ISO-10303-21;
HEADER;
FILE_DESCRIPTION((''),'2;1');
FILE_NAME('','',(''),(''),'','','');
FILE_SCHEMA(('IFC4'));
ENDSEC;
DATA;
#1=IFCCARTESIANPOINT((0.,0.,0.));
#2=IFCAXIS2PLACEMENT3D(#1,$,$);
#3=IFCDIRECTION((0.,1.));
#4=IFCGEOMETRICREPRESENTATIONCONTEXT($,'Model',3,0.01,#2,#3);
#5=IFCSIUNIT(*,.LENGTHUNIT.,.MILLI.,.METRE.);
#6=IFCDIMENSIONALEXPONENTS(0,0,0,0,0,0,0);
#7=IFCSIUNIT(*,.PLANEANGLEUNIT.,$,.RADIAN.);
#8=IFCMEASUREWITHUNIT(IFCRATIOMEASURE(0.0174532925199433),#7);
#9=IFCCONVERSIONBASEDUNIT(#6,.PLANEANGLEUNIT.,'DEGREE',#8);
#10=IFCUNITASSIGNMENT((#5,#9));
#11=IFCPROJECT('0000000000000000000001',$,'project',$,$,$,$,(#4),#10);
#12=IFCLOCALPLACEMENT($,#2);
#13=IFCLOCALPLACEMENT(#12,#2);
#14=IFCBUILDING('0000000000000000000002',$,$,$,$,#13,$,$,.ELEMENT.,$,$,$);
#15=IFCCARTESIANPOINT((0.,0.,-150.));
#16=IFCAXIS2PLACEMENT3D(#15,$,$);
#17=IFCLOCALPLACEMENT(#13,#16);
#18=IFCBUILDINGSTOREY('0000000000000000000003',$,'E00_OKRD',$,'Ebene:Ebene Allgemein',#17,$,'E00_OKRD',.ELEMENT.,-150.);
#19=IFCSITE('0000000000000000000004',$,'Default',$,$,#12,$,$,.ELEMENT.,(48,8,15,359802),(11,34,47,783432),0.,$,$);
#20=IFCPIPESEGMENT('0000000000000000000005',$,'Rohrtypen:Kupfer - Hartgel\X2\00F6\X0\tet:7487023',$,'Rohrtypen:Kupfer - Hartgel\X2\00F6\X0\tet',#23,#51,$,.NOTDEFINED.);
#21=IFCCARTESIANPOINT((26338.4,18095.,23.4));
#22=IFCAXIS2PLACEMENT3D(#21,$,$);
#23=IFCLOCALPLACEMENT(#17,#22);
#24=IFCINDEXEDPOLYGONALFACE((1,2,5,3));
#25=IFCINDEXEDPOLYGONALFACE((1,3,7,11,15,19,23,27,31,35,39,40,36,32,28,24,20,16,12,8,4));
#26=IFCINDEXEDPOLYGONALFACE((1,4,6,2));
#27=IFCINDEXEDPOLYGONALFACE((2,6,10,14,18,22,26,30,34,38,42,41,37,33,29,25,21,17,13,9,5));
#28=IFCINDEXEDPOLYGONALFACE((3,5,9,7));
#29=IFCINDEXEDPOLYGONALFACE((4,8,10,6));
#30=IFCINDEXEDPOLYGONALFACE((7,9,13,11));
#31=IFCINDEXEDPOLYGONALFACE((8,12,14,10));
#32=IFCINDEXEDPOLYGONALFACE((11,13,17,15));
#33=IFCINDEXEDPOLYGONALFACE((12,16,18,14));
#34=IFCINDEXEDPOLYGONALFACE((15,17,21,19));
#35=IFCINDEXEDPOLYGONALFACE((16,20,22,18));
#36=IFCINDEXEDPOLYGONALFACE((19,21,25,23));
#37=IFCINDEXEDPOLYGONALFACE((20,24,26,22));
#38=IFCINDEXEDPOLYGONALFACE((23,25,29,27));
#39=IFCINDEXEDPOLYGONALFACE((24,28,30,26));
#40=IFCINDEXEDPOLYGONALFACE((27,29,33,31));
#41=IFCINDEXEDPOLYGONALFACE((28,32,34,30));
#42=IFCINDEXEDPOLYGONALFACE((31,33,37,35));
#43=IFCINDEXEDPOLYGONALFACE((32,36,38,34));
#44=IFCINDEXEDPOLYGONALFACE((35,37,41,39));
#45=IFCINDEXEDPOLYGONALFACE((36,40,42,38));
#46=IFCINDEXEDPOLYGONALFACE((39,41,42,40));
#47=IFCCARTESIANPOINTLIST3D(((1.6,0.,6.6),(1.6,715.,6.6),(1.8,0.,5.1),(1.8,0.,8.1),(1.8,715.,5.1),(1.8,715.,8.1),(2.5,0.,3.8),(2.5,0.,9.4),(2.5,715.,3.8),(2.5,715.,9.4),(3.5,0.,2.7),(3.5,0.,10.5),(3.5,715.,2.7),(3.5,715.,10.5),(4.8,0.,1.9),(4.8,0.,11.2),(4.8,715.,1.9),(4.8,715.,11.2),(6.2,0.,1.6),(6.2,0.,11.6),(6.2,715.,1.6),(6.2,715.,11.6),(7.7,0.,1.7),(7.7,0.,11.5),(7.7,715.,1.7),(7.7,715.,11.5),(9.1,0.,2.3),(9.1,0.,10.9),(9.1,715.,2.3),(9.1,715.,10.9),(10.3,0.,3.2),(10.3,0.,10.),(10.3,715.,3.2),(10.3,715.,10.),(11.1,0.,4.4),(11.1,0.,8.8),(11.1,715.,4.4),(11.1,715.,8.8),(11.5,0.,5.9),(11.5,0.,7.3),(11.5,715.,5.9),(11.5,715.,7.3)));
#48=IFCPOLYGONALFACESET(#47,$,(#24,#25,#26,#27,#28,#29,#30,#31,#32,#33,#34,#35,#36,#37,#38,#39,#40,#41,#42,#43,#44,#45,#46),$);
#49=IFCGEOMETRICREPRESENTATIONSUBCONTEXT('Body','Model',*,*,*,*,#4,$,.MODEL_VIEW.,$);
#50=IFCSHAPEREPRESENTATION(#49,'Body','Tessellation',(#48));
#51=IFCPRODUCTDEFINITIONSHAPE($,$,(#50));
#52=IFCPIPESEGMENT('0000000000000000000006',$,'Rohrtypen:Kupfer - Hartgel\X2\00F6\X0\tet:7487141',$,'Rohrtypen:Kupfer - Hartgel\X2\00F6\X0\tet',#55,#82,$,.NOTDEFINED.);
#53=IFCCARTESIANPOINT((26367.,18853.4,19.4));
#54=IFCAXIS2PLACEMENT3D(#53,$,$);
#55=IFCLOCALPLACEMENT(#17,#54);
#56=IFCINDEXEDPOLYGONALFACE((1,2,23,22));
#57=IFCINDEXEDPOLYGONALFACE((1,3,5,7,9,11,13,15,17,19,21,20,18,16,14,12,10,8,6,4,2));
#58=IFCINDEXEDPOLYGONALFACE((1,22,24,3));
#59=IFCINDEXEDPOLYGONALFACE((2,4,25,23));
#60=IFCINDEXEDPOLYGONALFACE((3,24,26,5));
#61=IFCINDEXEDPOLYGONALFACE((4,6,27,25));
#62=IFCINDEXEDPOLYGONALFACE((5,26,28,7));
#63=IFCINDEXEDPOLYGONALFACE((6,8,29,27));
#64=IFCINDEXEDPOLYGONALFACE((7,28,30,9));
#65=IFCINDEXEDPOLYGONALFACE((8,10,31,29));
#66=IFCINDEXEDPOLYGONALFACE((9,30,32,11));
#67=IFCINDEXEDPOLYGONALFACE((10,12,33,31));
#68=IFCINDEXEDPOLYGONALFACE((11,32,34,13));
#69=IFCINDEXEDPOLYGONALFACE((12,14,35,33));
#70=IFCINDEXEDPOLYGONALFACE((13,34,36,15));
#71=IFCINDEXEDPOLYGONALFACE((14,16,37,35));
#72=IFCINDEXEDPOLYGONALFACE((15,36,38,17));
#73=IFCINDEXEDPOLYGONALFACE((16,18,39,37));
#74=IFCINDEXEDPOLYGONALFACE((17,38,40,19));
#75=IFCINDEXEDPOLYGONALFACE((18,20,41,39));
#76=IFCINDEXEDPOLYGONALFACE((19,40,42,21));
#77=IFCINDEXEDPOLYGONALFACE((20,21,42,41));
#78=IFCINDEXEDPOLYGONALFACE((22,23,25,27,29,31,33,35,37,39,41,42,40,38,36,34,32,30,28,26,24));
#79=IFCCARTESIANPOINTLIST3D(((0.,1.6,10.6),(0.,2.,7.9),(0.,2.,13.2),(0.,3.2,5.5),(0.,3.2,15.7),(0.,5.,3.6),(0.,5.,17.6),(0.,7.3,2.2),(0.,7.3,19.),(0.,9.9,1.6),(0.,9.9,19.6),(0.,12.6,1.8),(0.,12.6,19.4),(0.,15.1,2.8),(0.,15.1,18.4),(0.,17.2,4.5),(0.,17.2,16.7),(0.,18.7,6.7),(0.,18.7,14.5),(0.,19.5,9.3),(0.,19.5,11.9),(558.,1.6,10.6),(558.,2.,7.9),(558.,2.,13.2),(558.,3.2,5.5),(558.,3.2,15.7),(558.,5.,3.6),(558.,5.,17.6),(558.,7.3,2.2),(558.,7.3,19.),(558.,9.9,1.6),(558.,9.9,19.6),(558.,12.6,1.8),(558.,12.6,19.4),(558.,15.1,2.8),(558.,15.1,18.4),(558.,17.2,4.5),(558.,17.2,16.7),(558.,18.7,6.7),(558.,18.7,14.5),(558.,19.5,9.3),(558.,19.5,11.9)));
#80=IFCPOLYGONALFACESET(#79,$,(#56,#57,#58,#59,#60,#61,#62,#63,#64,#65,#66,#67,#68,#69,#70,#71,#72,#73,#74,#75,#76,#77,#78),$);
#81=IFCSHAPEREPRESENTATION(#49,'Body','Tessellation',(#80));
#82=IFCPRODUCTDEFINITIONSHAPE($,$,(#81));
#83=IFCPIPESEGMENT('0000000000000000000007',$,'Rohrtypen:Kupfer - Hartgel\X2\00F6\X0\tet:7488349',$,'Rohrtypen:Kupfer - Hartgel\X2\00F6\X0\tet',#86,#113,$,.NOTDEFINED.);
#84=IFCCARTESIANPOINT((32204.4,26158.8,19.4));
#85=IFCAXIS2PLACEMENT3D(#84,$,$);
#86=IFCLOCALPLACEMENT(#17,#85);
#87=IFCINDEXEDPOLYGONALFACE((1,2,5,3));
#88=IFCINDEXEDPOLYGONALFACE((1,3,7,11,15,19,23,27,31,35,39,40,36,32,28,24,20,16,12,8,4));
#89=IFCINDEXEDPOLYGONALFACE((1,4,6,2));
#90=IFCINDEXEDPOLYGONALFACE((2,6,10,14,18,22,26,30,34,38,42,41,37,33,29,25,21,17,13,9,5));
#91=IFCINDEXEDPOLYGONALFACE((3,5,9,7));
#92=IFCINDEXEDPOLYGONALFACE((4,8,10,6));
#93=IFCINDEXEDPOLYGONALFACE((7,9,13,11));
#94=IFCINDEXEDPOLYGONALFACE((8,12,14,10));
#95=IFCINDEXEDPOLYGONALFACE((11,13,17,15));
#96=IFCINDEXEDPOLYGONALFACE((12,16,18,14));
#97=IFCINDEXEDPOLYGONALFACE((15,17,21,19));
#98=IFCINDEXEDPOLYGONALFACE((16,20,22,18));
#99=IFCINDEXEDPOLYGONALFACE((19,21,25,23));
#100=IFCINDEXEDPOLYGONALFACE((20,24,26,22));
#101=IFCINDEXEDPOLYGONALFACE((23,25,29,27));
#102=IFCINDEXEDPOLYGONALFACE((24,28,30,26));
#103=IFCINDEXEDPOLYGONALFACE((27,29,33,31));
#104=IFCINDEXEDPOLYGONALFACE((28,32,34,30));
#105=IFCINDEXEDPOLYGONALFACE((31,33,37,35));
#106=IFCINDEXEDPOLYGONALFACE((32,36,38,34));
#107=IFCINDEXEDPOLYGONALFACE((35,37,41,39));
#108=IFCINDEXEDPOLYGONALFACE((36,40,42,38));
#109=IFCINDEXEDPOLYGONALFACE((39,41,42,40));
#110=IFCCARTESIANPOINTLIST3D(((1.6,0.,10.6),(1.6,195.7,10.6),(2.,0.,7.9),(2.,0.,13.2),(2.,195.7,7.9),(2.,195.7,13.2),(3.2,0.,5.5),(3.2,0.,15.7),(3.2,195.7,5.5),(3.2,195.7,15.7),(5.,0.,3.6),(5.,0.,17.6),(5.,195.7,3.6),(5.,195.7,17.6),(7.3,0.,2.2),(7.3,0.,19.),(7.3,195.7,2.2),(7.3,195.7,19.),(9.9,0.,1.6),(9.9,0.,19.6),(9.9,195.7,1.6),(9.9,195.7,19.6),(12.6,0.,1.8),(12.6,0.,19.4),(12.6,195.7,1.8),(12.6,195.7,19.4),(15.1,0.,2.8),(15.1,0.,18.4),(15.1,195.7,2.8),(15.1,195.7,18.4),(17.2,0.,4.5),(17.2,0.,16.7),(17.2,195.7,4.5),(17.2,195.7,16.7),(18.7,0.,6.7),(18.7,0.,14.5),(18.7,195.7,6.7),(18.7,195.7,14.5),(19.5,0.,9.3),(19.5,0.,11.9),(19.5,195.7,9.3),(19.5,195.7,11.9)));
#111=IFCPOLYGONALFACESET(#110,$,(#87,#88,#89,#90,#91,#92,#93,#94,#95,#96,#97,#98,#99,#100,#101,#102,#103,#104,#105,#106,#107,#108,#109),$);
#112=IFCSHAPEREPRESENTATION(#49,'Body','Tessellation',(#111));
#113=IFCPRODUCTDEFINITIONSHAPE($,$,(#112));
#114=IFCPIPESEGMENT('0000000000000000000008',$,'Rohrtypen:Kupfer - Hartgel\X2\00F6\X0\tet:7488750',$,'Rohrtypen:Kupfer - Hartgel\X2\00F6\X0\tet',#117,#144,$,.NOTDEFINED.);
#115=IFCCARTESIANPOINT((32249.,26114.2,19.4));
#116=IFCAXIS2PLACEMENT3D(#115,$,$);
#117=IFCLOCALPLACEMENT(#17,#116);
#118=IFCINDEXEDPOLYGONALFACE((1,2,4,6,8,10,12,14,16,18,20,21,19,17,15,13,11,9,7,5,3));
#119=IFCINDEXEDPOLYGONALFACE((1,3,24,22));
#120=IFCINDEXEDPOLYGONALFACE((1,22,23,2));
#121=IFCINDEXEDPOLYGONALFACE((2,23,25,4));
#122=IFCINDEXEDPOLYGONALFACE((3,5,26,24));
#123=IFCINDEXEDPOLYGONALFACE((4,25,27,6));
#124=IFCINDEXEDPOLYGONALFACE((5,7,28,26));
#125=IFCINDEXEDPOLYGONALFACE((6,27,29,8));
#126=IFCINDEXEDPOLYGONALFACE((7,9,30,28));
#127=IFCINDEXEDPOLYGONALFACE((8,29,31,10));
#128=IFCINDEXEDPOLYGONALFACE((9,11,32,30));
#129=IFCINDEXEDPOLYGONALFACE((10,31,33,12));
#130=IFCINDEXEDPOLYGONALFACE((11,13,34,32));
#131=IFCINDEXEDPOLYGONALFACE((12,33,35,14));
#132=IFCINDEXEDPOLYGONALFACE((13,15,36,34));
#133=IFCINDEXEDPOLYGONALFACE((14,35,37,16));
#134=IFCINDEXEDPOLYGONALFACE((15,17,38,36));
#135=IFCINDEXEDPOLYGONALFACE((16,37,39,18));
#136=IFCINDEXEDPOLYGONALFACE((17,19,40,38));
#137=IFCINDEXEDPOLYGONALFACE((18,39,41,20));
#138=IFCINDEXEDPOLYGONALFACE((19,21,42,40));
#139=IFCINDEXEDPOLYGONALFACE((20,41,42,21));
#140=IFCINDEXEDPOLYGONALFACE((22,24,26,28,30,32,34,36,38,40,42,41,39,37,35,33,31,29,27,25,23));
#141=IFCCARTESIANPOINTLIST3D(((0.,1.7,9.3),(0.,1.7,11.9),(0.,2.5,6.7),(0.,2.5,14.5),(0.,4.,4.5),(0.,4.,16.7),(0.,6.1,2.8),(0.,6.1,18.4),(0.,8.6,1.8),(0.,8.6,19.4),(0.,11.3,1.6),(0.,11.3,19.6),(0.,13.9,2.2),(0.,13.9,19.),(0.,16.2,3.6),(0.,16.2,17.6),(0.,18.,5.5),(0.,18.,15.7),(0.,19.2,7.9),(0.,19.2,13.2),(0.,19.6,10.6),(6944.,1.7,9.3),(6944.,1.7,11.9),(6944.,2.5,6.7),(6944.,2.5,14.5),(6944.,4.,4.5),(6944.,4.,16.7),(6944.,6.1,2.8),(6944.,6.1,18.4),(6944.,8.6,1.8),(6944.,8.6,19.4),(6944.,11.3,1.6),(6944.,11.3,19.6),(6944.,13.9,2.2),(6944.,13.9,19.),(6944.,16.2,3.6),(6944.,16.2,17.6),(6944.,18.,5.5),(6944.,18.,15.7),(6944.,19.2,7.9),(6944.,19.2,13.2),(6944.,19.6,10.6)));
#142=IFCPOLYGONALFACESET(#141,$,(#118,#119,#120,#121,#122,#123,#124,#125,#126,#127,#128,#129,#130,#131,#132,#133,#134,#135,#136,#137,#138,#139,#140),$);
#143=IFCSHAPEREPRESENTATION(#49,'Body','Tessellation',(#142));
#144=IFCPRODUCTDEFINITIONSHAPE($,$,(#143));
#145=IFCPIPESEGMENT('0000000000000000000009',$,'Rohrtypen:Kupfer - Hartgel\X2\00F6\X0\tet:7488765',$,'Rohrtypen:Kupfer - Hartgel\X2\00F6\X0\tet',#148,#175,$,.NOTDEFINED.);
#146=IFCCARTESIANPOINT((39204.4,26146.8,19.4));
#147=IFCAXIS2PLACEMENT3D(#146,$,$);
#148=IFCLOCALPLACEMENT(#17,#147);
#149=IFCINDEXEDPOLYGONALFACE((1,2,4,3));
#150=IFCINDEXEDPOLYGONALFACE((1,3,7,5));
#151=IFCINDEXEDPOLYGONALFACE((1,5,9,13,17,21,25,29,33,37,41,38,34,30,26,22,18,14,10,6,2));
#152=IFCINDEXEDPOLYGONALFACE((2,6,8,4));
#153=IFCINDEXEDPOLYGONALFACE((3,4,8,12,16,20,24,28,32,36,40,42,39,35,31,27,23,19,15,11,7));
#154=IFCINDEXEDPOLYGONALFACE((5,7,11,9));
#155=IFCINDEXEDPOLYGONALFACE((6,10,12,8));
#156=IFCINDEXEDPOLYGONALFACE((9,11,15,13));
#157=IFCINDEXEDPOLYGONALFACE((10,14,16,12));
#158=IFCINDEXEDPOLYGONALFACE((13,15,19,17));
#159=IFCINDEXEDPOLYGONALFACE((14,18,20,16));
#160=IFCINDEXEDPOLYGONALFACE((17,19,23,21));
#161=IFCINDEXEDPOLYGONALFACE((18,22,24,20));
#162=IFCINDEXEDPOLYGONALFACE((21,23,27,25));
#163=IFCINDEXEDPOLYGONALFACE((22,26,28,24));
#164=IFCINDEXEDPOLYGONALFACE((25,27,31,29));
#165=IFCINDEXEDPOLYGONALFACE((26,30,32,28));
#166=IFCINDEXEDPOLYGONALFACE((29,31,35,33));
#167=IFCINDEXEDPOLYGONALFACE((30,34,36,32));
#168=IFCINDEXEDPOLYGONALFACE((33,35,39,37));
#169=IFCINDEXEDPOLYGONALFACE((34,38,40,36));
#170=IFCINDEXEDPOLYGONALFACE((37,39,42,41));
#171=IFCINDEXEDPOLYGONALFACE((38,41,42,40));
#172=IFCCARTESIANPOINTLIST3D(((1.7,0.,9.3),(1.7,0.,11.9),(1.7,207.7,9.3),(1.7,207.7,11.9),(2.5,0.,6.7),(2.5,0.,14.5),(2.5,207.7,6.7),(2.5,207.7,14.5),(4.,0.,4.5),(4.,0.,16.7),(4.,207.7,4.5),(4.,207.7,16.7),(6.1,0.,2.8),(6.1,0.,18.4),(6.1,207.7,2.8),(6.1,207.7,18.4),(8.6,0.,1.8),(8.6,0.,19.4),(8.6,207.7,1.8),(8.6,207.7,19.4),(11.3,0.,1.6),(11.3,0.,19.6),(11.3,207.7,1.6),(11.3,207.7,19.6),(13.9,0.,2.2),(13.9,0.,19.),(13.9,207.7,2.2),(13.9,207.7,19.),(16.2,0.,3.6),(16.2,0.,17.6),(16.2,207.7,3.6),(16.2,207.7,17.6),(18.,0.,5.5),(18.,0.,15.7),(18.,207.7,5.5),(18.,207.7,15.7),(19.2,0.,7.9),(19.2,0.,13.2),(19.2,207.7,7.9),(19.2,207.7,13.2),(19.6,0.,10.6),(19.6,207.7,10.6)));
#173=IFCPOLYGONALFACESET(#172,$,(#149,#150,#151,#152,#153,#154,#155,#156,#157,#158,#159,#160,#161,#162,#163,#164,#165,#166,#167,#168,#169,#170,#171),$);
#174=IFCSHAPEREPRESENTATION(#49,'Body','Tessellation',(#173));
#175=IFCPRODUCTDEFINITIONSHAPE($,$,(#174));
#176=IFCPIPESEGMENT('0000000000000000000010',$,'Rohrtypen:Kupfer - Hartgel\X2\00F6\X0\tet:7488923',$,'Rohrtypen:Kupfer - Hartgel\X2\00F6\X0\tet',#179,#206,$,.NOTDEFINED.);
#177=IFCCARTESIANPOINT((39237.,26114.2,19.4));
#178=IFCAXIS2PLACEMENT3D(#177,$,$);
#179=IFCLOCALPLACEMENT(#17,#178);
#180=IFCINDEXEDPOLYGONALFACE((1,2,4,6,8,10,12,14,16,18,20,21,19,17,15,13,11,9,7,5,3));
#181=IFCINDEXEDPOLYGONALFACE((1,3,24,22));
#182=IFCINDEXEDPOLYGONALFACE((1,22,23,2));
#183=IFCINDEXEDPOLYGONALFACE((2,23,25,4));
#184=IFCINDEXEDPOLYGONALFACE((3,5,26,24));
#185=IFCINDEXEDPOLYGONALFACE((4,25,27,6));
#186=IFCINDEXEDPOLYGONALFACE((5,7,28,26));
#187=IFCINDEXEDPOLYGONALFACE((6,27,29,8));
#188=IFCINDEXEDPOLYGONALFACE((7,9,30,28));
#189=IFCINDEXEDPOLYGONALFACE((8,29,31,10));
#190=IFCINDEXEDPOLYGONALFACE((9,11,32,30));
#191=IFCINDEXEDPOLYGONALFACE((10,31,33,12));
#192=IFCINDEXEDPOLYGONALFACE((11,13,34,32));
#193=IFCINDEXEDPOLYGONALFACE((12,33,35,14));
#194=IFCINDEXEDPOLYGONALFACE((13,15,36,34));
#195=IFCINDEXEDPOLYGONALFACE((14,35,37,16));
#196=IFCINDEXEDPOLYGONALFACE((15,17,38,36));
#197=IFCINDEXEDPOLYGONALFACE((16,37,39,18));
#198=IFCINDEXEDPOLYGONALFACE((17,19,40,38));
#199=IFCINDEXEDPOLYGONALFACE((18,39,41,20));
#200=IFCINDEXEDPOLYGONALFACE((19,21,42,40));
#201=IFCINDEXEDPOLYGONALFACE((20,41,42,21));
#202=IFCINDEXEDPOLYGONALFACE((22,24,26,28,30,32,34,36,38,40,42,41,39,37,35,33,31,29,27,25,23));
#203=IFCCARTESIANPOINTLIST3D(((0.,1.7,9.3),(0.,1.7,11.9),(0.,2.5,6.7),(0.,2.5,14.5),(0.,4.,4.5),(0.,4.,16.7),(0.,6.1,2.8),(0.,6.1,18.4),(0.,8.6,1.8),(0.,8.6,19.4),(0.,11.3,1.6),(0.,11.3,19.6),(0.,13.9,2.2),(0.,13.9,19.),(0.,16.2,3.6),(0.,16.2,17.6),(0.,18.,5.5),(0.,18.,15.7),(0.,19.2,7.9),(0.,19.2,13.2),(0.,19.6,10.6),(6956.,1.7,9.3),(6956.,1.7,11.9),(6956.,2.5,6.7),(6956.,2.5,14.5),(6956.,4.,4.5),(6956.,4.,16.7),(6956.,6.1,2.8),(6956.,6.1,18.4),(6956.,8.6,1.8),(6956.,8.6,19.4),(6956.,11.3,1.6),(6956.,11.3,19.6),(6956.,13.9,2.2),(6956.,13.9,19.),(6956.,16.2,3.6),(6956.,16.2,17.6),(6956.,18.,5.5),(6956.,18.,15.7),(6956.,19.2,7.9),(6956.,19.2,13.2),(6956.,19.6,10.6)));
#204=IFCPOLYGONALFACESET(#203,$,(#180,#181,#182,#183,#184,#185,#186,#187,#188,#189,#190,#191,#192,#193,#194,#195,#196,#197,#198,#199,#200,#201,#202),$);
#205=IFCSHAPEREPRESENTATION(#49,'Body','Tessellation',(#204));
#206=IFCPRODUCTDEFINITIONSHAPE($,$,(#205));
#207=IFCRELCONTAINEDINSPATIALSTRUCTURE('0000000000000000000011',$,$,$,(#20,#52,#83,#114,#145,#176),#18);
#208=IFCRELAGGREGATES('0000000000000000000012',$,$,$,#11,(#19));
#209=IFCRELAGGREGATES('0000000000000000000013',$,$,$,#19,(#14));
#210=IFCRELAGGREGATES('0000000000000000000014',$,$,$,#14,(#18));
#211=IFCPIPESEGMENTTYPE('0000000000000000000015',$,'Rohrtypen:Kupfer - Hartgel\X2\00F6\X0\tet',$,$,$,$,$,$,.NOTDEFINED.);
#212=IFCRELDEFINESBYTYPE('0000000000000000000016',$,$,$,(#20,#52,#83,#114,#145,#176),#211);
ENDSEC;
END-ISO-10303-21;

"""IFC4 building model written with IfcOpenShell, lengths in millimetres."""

from ifc_helpers import new_model, entity, si_unit, converted_unit, direction, frame, frame_2d, origin, origin_2d_with_axis, place, context, subcontext, project, spatial, circle, extrude, type_object, element, save


model = new_model("IFC4")

# Units and contexts
model_context = context("Model", 3, precision=0.01, world=origin(), true_north=direction((0.0, 1.0)))
body_context = subcontext(model_context, "Body", "Model", "MODEL_VIEW")
ifc_project = project(units=[si_unit("LENGTHUNIT", "METRE", prefix="MILLI"), converted_unit("PLANEANGLEUNIT", "DEGREE", entity("IfcRatioMeasure", 0.0174532925199433), si_unit("PLANEANGLEUNIT", "RADIAN"), dimensions=[0, 0, 0, 0, 0, 0, 0])], contexts=[model_context])

# Site, building, storey
site_placement = place(None, origin())
site = spatial("IfcSite", under=ifc_project, at=site_placement, Name="Default", CompositionType="ELEMENT", RefLatitude=(48, 8, 15, 359802), RefLongitude=(11, 34, 47, 783432), RefElevation=0.0)
building_placement = place(site_placement, origin())
building = spatial("IfcBuilding", under=site, at=building_placement, CompositionType="ELEMENT")
storey_placement = place(building_placement, frame((0.0, 0.0, -150.0)))
storey = spatial("IfcBuildingStorey", under=building, at=storey_placement, Name="E00_OKRD", ObjectType="Ebene:Ebene Allgemein", LongName="E00_OKRD", CompositionType="ELEMENT", Elevation=-150.0)

# Pipe segments
pipe_segment_type = type_object("IfcPipeSegmentType", Name="Rohrtypen:Kupfer - Hartgelötet", PredefinedType="NOTDEFINED")
pipe_segment_1_placement = place(storey_placement, frame((26338.4, 18095.0, 23.4)))
element("IfcPipeSegment", 1, at=pipe_segment_1_placement, inside=storey, type_object=pipe_segment_type, Name="Rohrtypen:Kupfer - Hartgelötet:7487023", ObjectType="Rohrtypen:Kupfer - Hartgelötet", PredefinedType="NOTDEFINED", context=body_context, shape_type="SweptSolid", body=[
    extrude(circle(Radius=5.0, at=frame_2d((0.0, 0.0), x_axis=(1.0, 0.0))), frame((6.6, 0.0, 6.6), z_axis=(0.0, 1.0, 0.0), x_axis=(-1.0, 0.0, 0.0)), (0.0, 0.0, 1.0), 715.0),
])
pipe_segment_2_placement = place(storey_placement, frame((26367.0, 18853.4, 19.4)))
element("IfcPipeSegment", 2, at=pipe_segment_2_placement, inside=storey, type_object=pipe_segment_type, Name="Rohrtypen:Kupfer - Hartgelötet:7487141", ObjectType="Rohrtypen:Kupfer - Hartgelötet", PredefinedType="NOTDEFINED", context=body_context, shape_type="SweptSolid", body=[
    extrude(circle(Radius=9.0, at=origin_2d_with_axis()), frame((0.0, 10.6, 10.6), z_axis=(1.0, 0.0, 0.0), x_axis=(0.0, -1.0, 0.0)), (0.0, 0.0, 1.0), 558.0),
])
pipe_segment_3_placement = place(storey_placement, frame((32204.4, 26158.8, 19.4)))
element("IfcPipeSegment", 3, at=pipe_segment_3_placement, inside=storey, type_object=pipe_segment_type, Name="Rohrtypen:Kupfer - Hartgelötet:7488349", ObjectType="Rohrtypen:Kupfer - Hartgelötet", PredefinedType="NOTDEFINED", context=body_context, shape_type="SweptSolid", body=[
    extrude(circle(Radius=9.0, at=frame_2d((0.0, 0.0), x_axis=(1.0, 0.0))), frame((10.6, 0.0, 10.6), z_axis=(0.0, 1.0, 0.0), x_axis=(-1.0, 0.0, 0.0)), (0.0, 0.0, 1.0), 195.7),
])
pipe_segment_4_placement = place(storey_placement, frame((32249.0, 26114.2, 19.4)))
element("IfcPipeSegment", 4, at=pipe_segment_4_placement, inside=storey, type_object=pipe_segment_type, Name="Rohrtypen:Kupfer - Hartgelötet:7488750", ObjectType="Rohrtypen:Kupfer - Hartgelötet", PredefinedType="NOTDEFINED", context=body_context, shape_type="SweptSolid", body=[
    extrude(circle(Radius=9.0, at=frame_2d((0.0, 0.0), x_axis=(1.0, 0.0))), frame((0.0, 10.6, 10.6), z_axis=(1.0, 0.0, 0.0), x_axis=(0.0, 1.0, 0.0)), (0.0, 0.0, 1.0), 6944.0),
])
pipe_segment_5_placement = place(storey_placement, frame((39204.4, 26146.8, 19.4)))
element("IfcPipeSegment", 5, at=pipe_segment_5_placement, inside=storey, type_object=pipe_segment_type, Name="Rohrtypen:Kupfer - Hartgelötet:7488765", ObjectType="Rohrtypen:Kupfer - Hartgelötet", PredefinedType="NOTDEFINED", context=body_context, shape_type="SweptSolid", body=[
    extrude(circle(Radius=9.0, at=frame_2d((0.0, 0.0), x_axis=(1.0, 0.0))), frame((10.6, 0.0, 10.6), z_axis=(0.0, 1.0, 0.0), x_axis=(1.0, 0.0, 0.0)), (0.0, 0.0, 1.0), 207.7),
])
pipe_segment_6_placement = place(storey_placement, frame((39237.0, 26114.2, 19.4)))
element("IfcPipeSegment", 6, at=pipe_segment_6_placement, inside=storey, type_object=pipe_segment_type, Name="Rohrtypen:Kupfer - Hartgelötet:7488923", ObjectType="Rohrtypen:Kupfer - Hartgelötet", PredefinedType="NOTDEFINED", context=body_context, shape_type="SweptSolid", body=[
    extrude(circle(Radius=9.0, at=frame_2d((0.0, 0.0), x_axis=(1.0, 0.0))), frame((0.0, 10.6, 10.6), z_axis=(1.0, 0.0, 0.0), x_axis=(0.0, 1.0, 0.0)), (0.0, 0.0, 1.0), 6956.0),
])

save(model, "model.ifc")
